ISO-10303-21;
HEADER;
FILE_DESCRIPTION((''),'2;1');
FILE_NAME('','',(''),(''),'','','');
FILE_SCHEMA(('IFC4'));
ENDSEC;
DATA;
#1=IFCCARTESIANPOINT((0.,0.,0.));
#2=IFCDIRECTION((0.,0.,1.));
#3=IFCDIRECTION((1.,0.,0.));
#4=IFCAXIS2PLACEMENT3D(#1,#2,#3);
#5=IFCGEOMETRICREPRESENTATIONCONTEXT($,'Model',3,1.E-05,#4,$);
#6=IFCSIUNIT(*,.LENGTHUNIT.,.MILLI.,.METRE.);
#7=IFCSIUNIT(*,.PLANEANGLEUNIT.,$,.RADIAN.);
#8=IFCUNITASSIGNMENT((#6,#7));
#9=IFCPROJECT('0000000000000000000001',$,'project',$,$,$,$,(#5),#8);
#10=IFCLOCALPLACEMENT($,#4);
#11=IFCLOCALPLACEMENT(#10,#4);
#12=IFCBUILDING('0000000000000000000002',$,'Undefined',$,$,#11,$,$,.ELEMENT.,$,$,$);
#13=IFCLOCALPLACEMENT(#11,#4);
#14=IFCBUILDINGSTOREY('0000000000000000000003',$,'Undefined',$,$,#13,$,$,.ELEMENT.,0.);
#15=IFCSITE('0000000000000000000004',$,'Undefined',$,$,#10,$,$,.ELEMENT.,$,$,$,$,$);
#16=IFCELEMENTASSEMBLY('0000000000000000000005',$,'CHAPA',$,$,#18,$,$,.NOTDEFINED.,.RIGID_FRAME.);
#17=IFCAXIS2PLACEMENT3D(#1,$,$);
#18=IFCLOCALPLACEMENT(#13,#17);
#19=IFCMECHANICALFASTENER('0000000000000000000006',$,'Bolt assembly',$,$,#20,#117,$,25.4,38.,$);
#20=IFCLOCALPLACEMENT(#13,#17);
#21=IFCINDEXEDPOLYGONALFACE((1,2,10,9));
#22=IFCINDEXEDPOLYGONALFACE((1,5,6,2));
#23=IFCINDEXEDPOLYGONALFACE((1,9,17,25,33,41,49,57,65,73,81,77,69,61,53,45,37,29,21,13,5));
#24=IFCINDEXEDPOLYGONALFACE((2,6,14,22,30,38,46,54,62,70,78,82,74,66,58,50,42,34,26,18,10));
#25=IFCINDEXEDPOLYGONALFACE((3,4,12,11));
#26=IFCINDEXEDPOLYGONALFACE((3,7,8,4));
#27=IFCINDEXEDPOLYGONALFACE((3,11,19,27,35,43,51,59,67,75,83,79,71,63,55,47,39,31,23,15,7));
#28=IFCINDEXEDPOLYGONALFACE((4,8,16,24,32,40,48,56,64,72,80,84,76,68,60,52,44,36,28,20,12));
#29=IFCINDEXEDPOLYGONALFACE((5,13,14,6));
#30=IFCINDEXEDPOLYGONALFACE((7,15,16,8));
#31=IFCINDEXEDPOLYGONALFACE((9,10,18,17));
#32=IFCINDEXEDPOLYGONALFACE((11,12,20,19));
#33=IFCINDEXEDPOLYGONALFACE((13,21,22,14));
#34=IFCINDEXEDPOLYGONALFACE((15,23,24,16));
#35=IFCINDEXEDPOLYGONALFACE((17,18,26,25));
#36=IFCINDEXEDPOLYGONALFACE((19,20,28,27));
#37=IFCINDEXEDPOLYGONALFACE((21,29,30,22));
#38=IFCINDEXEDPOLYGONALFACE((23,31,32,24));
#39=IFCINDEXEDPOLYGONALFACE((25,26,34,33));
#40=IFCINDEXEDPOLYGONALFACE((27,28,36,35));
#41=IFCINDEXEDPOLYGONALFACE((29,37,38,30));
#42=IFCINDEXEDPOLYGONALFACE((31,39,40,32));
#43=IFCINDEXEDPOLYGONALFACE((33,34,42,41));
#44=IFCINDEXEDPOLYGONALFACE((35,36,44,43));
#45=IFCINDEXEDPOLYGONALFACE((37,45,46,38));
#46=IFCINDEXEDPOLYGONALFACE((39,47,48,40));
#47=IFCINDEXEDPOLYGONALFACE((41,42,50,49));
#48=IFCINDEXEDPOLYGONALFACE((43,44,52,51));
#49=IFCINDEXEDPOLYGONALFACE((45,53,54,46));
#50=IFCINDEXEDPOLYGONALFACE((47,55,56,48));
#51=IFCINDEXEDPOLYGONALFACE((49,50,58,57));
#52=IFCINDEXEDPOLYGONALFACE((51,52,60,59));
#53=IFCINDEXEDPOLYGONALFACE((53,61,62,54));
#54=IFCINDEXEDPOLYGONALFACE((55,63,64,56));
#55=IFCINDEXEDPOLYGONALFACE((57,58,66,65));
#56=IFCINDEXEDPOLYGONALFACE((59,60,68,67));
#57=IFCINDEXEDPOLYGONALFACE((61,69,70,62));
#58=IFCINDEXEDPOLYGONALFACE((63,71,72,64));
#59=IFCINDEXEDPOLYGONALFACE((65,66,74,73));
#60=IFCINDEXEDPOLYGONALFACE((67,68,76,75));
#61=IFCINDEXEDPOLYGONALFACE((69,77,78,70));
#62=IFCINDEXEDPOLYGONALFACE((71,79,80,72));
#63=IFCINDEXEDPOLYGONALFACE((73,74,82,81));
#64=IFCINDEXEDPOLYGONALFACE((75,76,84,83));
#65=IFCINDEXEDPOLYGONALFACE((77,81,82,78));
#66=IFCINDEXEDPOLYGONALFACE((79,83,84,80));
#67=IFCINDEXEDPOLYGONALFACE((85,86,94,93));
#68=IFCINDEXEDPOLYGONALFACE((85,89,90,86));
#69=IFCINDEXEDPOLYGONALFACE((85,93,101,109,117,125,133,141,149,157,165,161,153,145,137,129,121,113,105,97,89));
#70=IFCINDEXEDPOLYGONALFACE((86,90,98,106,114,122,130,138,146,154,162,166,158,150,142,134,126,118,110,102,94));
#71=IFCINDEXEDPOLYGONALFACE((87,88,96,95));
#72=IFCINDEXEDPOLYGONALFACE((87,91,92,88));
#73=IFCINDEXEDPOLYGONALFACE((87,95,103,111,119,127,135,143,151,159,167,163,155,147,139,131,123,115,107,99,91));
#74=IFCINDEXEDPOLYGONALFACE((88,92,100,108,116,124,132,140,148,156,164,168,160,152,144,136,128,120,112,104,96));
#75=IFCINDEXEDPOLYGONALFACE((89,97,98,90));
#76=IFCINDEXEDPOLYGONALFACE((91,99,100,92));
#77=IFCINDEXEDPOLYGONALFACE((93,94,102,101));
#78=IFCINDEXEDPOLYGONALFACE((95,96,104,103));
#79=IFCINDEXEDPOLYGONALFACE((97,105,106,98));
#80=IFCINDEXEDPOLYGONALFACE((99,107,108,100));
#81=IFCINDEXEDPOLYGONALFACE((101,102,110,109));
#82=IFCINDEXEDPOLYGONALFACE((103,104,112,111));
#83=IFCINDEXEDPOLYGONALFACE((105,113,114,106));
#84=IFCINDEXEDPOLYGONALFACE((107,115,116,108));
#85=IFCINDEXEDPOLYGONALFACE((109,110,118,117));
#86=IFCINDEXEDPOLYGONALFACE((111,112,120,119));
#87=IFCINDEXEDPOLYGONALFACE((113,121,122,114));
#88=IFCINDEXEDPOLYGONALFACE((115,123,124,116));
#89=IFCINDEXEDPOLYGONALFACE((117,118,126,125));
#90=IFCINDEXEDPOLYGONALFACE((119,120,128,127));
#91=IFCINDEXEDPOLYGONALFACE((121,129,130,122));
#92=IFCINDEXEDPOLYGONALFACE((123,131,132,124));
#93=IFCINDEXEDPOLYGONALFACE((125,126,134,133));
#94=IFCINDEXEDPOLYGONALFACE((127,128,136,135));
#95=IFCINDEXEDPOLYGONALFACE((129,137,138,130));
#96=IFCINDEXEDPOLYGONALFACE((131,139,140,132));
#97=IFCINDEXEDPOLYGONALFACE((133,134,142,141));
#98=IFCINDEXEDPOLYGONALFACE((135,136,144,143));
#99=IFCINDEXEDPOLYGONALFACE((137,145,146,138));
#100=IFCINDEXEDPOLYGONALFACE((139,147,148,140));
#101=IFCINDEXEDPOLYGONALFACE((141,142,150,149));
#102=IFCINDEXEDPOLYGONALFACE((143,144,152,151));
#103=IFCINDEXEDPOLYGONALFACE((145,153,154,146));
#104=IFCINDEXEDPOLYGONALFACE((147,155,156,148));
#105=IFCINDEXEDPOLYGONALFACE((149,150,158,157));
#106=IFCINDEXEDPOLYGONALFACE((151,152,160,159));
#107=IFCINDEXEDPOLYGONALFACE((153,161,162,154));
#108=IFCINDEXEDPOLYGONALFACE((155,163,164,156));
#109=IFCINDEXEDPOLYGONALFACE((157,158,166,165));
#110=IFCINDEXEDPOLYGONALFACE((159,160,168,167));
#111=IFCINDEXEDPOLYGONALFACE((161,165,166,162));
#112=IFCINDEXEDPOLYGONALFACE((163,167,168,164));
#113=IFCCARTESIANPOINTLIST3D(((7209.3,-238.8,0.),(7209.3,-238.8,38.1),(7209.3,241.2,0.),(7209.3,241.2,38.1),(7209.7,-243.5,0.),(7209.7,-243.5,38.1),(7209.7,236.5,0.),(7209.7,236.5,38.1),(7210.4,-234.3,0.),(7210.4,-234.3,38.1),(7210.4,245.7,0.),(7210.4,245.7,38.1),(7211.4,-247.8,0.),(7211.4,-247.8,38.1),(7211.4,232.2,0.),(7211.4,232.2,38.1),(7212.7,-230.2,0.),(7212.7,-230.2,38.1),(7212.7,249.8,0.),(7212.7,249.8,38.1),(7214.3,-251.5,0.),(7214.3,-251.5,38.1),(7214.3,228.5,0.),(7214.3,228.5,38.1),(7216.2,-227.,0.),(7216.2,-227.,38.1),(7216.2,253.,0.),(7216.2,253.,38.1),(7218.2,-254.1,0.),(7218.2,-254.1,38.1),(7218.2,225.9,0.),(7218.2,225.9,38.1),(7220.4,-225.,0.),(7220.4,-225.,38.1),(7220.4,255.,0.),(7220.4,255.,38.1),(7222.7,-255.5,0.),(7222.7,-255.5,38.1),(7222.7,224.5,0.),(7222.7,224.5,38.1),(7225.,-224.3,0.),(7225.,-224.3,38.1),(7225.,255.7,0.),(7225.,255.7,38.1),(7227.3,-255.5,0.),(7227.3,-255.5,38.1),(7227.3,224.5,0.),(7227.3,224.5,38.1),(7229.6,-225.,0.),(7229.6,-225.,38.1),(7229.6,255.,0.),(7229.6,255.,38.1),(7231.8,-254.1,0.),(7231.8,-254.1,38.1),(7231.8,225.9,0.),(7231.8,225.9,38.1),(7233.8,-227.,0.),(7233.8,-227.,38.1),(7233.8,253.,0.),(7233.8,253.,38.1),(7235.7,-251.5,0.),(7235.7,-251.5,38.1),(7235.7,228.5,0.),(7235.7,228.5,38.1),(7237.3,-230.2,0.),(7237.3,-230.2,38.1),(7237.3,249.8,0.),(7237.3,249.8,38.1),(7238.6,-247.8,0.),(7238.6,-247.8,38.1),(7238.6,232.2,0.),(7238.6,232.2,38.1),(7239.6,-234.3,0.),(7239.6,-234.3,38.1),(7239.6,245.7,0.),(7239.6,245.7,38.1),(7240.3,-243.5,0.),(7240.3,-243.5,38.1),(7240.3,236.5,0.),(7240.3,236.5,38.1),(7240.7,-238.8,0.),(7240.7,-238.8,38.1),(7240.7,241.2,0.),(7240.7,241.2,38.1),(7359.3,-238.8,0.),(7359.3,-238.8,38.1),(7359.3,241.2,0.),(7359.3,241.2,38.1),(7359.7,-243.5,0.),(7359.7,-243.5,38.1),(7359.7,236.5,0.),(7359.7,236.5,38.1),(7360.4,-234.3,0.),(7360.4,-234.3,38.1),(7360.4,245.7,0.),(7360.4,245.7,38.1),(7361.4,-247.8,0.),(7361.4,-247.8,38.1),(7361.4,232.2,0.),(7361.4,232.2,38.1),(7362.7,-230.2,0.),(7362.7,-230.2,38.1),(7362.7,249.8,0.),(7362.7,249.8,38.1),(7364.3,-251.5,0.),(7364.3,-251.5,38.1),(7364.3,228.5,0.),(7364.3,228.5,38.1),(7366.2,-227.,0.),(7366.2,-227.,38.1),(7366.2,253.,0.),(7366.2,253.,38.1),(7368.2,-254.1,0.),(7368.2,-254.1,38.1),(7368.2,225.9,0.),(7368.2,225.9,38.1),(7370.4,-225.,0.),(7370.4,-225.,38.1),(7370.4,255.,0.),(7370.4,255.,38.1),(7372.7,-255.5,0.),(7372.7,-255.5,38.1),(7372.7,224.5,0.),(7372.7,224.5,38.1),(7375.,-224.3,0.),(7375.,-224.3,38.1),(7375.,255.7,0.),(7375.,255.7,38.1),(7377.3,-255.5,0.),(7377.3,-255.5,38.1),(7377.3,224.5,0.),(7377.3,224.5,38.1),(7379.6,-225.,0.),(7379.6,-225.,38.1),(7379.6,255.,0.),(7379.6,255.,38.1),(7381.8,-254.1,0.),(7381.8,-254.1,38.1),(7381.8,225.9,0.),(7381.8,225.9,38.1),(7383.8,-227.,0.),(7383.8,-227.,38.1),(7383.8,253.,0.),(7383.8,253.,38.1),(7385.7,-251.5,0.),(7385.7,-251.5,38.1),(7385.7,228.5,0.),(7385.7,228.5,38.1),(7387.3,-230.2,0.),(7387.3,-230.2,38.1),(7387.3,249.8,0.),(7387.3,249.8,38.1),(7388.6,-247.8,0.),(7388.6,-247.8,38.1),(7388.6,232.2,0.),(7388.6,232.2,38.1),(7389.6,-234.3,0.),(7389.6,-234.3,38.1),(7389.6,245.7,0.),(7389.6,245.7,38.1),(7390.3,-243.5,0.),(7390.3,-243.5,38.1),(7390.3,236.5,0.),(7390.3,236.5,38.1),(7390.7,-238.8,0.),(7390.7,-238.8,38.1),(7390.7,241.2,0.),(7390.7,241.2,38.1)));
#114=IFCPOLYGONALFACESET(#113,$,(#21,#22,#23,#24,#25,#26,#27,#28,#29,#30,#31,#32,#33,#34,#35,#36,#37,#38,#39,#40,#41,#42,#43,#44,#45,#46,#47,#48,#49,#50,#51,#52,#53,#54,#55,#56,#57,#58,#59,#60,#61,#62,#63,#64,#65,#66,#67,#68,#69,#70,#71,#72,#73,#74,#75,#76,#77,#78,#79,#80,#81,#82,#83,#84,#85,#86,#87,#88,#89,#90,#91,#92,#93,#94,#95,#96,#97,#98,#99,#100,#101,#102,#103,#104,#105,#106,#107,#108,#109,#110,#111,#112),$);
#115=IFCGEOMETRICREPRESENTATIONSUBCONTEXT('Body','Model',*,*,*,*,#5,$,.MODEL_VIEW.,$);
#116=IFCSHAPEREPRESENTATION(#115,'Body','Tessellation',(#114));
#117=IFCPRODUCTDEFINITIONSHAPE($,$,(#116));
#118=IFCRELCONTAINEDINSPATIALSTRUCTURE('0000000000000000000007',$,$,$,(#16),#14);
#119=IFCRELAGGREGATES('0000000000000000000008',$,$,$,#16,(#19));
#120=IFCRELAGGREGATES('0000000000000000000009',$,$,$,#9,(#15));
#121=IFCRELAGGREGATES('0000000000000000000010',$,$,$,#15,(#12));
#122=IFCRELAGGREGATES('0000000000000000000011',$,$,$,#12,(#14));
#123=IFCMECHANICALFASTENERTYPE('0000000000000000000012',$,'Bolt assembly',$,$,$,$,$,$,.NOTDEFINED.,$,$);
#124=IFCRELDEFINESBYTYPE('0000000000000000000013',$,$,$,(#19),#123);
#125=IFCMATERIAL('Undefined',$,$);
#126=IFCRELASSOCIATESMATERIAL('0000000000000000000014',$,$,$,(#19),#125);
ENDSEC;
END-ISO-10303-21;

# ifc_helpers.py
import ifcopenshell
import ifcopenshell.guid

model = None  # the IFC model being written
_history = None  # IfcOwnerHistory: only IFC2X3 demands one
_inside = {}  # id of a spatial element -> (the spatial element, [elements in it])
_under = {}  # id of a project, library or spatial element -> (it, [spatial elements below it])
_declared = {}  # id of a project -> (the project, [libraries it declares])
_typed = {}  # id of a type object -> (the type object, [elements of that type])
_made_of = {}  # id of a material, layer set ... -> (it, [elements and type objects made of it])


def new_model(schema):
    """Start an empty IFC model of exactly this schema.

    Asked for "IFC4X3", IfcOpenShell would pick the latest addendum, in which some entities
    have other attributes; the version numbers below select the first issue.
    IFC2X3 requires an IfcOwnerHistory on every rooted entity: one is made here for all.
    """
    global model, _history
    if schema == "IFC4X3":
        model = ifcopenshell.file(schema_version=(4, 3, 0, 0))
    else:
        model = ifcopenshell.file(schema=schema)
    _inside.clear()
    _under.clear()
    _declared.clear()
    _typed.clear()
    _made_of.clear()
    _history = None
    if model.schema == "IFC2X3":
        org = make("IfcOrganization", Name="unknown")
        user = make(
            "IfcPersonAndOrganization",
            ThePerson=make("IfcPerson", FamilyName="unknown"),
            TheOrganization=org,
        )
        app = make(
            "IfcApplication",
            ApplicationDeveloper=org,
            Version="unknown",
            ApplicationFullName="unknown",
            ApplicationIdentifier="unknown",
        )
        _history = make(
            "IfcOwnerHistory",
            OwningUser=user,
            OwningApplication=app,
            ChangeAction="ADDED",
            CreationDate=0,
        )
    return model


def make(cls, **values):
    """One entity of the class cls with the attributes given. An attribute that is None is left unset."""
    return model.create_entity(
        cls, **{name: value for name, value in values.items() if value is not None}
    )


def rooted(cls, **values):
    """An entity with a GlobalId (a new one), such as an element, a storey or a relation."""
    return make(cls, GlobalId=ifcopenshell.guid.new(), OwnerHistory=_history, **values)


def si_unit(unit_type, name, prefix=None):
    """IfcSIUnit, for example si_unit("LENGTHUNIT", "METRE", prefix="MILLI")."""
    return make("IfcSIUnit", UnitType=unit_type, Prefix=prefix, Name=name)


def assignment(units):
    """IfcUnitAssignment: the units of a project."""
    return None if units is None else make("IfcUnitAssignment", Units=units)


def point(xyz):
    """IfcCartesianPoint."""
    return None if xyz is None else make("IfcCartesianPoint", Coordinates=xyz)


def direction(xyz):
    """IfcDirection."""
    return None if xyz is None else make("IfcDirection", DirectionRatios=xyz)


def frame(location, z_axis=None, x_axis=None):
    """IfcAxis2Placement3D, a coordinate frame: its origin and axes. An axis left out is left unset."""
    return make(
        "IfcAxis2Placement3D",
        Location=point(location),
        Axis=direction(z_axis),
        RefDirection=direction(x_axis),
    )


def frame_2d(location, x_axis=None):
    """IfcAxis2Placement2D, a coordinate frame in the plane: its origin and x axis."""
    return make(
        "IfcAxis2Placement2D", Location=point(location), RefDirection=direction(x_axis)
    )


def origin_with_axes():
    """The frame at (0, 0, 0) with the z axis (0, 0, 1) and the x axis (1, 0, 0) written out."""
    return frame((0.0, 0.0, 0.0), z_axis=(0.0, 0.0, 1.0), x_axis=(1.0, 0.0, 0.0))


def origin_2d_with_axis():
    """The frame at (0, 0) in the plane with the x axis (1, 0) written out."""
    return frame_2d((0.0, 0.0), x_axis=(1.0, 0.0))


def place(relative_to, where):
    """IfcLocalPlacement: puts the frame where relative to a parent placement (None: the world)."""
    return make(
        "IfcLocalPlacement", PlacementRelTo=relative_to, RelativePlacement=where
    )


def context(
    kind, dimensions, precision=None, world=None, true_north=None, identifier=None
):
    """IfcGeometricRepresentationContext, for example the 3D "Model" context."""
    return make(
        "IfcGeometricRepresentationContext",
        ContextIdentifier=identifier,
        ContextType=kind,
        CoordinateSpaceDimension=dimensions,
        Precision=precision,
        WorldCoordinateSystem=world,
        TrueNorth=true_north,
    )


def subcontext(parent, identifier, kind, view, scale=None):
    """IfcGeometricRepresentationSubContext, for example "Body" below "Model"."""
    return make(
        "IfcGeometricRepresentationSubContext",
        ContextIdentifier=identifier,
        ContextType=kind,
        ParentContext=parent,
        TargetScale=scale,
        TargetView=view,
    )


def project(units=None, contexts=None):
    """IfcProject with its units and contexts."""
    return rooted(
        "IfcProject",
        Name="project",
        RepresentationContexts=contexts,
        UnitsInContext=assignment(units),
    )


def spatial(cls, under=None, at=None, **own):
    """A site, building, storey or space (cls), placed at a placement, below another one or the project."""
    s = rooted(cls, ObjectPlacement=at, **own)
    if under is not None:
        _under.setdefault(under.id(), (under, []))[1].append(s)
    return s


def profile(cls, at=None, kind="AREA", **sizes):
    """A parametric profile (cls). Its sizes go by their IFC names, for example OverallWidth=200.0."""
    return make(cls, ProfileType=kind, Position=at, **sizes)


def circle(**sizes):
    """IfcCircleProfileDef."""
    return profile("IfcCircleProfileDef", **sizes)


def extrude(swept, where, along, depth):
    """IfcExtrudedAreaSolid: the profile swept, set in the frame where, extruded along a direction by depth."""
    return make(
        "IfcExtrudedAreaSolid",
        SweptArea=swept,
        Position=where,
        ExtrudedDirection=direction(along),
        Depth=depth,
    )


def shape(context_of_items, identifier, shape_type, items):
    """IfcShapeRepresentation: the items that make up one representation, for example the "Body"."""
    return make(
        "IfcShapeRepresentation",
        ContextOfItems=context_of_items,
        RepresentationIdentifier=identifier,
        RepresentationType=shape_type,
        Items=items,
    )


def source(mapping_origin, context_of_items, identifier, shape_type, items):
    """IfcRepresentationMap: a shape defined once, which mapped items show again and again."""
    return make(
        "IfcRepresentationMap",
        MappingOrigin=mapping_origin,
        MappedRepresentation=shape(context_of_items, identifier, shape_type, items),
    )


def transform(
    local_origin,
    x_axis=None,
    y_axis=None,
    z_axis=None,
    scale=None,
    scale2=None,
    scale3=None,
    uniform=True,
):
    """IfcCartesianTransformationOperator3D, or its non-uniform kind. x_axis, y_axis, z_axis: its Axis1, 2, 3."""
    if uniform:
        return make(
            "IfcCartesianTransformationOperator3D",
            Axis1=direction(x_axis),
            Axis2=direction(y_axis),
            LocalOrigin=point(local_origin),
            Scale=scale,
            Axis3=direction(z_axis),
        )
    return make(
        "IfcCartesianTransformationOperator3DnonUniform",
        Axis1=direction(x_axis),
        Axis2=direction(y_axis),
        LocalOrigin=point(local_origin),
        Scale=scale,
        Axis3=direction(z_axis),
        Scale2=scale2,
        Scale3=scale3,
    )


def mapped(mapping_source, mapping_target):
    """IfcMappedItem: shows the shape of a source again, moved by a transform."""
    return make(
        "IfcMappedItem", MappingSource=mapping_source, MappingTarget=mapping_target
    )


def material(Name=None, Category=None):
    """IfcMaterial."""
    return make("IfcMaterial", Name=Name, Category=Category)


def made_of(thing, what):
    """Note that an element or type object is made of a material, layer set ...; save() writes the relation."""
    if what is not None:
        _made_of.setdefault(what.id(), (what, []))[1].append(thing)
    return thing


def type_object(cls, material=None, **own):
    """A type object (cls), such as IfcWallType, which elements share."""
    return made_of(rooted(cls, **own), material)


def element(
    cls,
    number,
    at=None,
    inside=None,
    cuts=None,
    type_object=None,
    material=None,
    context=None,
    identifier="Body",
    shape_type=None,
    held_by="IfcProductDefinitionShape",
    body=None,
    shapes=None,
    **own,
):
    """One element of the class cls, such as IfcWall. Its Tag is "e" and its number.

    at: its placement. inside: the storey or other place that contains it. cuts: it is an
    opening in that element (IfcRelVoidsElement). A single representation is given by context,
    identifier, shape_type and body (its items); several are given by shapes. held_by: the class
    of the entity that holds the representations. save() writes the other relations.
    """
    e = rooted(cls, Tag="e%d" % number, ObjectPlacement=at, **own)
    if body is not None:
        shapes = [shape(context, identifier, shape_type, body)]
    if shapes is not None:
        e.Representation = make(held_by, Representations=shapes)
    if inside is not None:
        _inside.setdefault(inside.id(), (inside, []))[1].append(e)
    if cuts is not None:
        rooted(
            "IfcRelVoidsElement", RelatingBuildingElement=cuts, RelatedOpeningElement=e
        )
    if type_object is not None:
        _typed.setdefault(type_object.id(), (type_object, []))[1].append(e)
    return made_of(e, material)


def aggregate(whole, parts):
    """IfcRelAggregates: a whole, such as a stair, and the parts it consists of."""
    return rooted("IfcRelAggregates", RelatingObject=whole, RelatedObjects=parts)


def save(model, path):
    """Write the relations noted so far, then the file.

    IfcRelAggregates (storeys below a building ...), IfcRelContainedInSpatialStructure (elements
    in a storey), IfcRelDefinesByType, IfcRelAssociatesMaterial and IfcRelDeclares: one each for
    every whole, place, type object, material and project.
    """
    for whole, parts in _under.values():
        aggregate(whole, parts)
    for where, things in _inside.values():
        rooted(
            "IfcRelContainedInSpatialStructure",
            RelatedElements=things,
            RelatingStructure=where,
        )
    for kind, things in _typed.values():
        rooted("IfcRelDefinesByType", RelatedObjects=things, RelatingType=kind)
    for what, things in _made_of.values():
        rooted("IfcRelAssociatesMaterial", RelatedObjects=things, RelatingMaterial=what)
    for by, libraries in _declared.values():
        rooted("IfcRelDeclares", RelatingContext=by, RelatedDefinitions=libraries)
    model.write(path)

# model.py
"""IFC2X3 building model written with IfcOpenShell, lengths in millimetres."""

from ifc_helpers import new_model, si_unit, frame, origin_with_axes, origin_2d_with_axis, place, context, subcontext, project, spatial, circle, extrude, source, transform, mapped, material, type_object, element, aggregate, save


model = new_model("IFC2X3")

# Units and contexts
model_context = context("Model", 3, precision=1e-05, world=origin_with_axes())
body_context = subcontext(model_context, "Body", "Model", "MODEL_VIEW")
ifc_project = project(units=[si_unit("LENGTHUNIT", "METRE", prefix="MILLI"), si_unit("PLANEANGLEUNIT", "RADIAN")], contexts=[model_context])

# Site, building, storey
site_placement = place(None, origin_with_axes())
site = spatial("IfcSite", under=ifc_project, at=site_placement, Name="Undefined", CompositionType="ELEMENT")
building_placement = place(site_placement, origin_with_axes())
building = spatial("IfcBuilding", under=site, at=building_placement, Name="Undefined", CompositionType="ELEMENT")
storey_placement = place(building_placement, origin_with_axes())
storey = spatial("IfcBuildingStorey", under=building, at=storey_placement, Name="Undefined", CompositionType="ELEMENT", Elevation=0.0)

# Element assembly
assembly_1_placement = place(storey_placement, origin_with_axes())
assembly_1 = element("IfcElementAssembly", 1, at=assembly_1_placement, inside=storey, Name="CHAPA", AssemblyPlace="NOTDEFINED", PredefinedType="RIGID_FRAME")

# Shared definitions
ifc_material_1 = material(Name="Undefined")
mechanical_fastener_type = type_object("IfcMechanicalFastenerType", Name="Bolt assembly")

# Mechanical fastener
shared_shape_1 = source(origin_with_axes(), body_context, "Body", "SweptSolid", [
    extrude(circle(Radius=15.7, at=origin_2d_with_axis()), frame((0.0, -38.0, 0.0), z_axis=(0.0, 1.0, 0.0), x_axis=(1.0, 0.0, 0.0)), (0.0, 0.0, 1.0), 38.1),
])
mechanical_fastener_1_placement = place(assembly_1_placement, frame((7300.0, -240.0, 38.0), z_axis=(1.0, 0.0, 0.0), x_axis=(0.0, 1.0, 0.0)))
mechanical_fastener_1 = element("IfcMechanicalFastener", 2, at=mechanical_fastener_1_placement, type_object=mechanical_fastener_type, material=ifc_material_1, Name="Bolt assembly", NominalDiameter=25.4, NominalLength=38.0, context=body_context, shape_type="MappedRepresentation", body=[
    mapped(shared_shape_1, transform((0.0, 0.0, -75.0))),
    mapped(shared_shape_1, transform((0.0, 0.0, 75.0))),
    mapped(shared_shape_1, transform((480.0, 0.0, -75.0))),
    mapped(shared_shape_1, transform((480.0, 0.0, 75.0))),
])
aggregate(assembly_1, [mechanical_fastener_1])

save(model, "model.ifc")
